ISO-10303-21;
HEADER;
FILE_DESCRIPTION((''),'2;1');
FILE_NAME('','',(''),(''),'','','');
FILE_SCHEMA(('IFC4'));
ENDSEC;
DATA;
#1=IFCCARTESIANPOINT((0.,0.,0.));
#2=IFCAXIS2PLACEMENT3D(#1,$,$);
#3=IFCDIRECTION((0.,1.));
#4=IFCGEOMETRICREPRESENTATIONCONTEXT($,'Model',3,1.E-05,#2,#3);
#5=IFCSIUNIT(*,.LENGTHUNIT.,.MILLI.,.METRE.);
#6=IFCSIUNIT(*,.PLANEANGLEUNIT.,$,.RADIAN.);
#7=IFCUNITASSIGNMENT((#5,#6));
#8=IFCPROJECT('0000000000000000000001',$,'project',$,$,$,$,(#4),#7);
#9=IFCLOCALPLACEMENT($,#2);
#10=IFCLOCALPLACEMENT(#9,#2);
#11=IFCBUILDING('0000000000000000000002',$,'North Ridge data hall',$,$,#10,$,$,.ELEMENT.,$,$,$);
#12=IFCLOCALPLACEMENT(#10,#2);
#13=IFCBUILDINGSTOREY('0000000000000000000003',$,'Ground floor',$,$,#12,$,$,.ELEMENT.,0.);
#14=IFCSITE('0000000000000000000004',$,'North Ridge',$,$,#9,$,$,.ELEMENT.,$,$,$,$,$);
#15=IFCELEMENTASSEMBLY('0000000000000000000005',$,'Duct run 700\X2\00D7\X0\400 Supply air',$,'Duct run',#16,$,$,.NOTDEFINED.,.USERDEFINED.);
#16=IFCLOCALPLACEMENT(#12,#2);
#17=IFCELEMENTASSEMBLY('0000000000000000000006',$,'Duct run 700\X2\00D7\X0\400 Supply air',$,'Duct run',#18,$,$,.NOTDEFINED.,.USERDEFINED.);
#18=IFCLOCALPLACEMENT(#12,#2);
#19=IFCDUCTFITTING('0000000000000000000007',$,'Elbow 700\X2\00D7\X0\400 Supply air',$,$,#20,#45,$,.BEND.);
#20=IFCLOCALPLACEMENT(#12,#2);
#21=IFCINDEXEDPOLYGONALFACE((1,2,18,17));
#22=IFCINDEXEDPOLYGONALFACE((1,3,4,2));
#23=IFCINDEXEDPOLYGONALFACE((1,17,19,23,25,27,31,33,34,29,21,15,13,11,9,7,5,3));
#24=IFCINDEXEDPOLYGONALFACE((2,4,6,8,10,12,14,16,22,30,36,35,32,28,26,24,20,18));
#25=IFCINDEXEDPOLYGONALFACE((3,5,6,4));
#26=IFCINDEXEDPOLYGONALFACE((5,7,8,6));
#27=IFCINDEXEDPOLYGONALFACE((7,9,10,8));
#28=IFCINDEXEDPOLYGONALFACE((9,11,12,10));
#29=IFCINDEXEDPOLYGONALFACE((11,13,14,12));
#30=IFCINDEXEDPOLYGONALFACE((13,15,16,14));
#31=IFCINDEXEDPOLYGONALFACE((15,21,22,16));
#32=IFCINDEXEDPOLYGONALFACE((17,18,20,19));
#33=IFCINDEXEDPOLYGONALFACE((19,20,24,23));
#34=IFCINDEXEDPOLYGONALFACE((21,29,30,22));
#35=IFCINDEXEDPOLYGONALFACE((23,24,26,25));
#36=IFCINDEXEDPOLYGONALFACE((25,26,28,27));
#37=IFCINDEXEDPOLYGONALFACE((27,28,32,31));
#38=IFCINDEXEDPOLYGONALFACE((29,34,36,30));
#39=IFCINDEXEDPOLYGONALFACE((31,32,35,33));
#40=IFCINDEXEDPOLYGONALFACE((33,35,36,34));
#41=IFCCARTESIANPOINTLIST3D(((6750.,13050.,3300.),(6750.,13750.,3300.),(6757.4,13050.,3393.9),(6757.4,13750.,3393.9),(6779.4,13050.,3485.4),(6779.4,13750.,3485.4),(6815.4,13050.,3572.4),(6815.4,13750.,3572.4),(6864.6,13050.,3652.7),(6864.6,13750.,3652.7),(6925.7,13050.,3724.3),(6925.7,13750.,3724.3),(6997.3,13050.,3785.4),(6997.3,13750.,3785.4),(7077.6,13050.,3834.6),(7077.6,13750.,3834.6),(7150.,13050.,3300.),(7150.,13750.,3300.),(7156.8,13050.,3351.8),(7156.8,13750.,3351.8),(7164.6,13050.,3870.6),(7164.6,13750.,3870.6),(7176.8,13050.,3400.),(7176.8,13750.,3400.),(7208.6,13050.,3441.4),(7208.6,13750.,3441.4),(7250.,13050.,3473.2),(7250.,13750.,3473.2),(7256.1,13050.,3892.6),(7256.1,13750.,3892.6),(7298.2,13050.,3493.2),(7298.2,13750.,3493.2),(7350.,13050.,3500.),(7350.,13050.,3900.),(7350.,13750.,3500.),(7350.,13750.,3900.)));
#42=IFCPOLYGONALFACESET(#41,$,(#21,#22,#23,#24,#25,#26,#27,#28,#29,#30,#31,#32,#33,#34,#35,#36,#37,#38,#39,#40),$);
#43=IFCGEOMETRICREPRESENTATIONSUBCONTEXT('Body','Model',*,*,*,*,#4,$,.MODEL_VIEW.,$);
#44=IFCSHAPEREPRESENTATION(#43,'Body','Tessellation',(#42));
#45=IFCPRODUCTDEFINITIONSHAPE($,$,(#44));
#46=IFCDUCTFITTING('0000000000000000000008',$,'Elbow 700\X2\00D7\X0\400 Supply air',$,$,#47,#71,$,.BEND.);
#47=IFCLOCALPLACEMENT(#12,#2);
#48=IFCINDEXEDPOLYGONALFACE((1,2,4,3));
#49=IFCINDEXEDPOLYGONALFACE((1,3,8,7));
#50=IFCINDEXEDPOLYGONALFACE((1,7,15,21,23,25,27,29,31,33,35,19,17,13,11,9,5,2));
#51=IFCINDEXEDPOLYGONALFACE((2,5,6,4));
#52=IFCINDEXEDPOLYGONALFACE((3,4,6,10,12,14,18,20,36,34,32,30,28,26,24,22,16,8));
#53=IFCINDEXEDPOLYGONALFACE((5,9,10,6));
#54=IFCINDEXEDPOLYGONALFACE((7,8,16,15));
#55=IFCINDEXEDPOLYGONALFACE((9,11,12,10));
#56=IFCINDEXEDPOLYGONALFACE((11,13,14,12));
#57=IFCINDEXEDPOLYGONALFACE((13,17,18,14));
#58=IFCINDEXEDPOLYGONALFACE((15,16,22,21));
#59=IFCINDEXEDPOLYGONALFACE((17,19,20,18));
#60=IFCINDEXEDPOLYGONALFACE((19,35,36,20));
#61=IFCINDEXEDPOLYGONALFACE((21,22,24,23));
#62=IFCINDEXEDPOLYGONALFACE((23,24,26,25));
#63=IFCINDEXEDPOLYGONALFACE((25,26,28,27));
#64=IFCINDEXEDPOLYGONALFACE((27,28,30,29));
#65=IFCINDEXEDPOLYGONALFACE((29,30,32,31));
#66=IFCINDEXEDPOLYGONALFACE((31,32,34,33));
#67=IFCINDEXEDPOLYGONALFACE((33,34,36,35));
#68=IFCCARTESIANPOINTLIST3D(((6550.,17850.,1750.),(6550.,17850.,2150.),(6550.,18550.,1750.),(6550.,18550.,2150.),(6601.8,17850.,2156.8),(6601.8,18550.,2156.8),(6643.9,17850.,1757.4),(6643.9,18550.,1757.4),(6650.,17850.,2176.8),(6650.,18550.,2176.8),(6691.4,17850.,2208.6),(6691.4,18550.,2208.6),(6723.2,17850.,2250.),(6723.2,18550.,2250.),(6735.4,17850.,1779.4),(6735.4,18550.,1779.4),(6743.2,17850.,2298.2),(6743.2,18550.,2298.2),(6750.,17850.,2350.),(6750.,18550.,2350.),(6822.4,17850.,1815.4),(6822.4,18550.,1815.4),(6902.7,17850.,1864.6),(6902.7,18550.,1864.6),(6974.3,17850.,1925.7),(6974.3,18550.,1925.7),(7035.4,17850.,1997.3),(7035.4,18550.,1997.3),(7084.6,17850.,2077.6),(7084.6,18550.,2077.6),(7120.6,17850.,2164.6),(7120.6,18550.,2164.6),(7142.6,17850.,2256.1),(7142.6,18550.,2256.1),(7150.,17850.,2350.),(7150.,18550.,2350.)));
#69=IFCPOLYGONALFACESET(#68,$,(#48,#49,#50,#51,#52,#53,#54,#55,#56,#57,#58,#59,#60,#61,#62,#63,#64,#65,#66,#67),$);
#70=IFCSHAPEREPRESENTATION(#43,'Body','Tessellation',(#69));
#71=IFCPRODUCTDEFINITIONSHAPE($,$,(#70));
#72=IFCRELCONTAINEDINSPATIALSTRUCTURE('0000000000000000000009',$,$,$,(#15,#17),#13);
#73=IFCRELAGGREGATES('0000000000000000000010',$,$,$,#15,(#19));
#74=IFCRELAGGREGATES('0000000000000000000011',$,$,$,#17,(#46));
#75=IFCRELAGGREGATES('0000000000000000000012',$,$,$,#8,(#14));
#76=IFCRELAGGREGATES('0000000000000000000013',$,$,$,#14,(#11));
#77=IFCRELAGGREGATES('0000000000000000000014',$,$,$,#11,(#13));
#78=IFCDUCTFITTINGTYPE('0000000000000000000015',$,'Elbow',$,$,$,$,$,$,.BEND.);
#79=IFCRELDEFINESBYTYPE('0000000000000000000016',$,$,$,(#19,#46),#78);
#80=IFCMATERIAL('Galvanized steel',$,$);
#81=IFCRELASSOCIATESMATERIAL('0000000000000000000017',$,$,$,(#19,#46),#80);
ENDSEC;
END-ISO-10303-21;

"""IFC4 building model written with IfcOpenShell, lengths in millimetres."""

from ifc_helpers import new_model, entity, si_unit, direction, origin, origin_with_axes, place, context, subcontext, project, spatial, material, type_object, element, aggregate, save


model = new_model("IFC4")

# Units and contexts
model_context = context("Model", 3, precision=1e-05, world=origin(), true_north=direction((0.0, 1.0)))
body_context = subcontext(model_context, "Body", "Model", "MODEL_VIEW")
ifc_project = project(units=[si_unit("LENGTHUNIT", "METRE", prefix="MILLI"), si_unit("PLANEANGLEUNIT", "RADIAN")], contexts=[model_context])

# Site, building, storey
site_placement = place(None, origin())
site = spatial("IfcSite", under=ifc_project, at=site_placement, Name="North Ridge", CompositionType="ELEMENT")
building_placement = place(site_placement, origin())
building = spatial("IfcBuilding", under=site, at=building_placement, Name="North Ridge data hall", CompositionType="ELEMENT")
storey_placement = place(building_placement, origin())
storey = spatial("IfcBuildingStorey", under=building, at=storey_placement, Name="Ground floor", CompositionType="ELEMENT", Elevation=0.0)

# Element assembly
ifc_material_1 = material(Name="Galvanized steel")
assembly_1_placement = place(storey_placement, origin_with_axes())
assembly_1 = element("IfcElementAssembly", 1, at=assembly_1_placement, inside=storey, Name="Duct run 700×400 Supply air", ObjectType="Duct run", AssemblyPlace="NOTDEFINED", PredefinedType="USERDEFINED")

# Element assembly
assembly_2_placement = place(storey_placement, origin_with_axes())
assembly_2 = element("IfcElementAssembly", 2, at=assembly_2_placement, inside=storey, Name="Duct run 700×400 Supply air", ObjectType="Duct run", AssemblyPlace="NOTDEFINED", PredefinedType="USERDEFINED")

# Duct fittings
duct_fitting_type = type_object("IfcDuctFittingType", Name="Elbow", PredefinedType="BEND")
duct_fitting_1_placement = place(storey_placement, origin_with_axes())
duct_fitting_1 = element("IfcDuctFitting", 3, at=duct_fitting_1_placement, type_object=duct_fitting_type, material=ifc_material_1, Name="Elbow 700×400 Supply air", PredefinedType="BEND", context=body_context, shape_type="SweptSolid", body=[
    entity("IfcRevolvedAreaSolid", entity("IfcRectangleProfileDef", "AREA", None, entity("IfcAxis2Placement2D", entity("IfcCartesianPoint", [0.0, 0.0])), 700.0, 400.0), entity("IfcAxis2Placement3D", entity("IfcCartesianPoint", [6950.0, 13400.0, 3300.0]), entity("IfcDirection", [0.0, 0.0, 1.0]), entity("IfcDirection", [0.0, 1.0, 0.0])), entity("IfcAxis1Placement", entity("IfcCartesianPoint", [0.0, -400.0, 0.0]), entity("IfcDirection", [1.0, 0.0, 0.0])), 1.570796),
])
aggregate(assembly_1, [duct_fitting_1])
duct_fitting_2_placement = place(storey_placement, origin_with_axes())
duct_fitting_2 = element("IfcDuctFitting", 4, at=duct_fitting_2_placement, type_object=duct_fitting_type, material=ifc_material_1, Name="Elbow 700×400 Supply air", PredefinedType="BEND", context=body_context, shape_type="SweptSolid", body=[
    entity("IfcRevolvedAreaSolid", entity("IfcRectangleProfileDef", "AREA", None, entity("IfcAxis2Placement2D", entity("IfcCartesianPoint", [0.0, 0.0])), 700.0, 400.0), entity("IfcAxis2Placement3D", entity("IfcCartesianPoint", [6550.0, 18200.0, 1950.0]), entity("IfcDirection", [1.0, 0.0, 0.0]), entity("IfcDirection", [0.0, 1.0, 0.0])), entity("IfcAxis1Placement", entity("IfcCartesianPoint", [0.0, 400.0, 0.0]), entity("IfcDirection", [-1.0, 0.0, 0.0])), 1.570796),
])
aggregate(assembly_2, [duct_fitting_2])

save(model, "model.ifc")
